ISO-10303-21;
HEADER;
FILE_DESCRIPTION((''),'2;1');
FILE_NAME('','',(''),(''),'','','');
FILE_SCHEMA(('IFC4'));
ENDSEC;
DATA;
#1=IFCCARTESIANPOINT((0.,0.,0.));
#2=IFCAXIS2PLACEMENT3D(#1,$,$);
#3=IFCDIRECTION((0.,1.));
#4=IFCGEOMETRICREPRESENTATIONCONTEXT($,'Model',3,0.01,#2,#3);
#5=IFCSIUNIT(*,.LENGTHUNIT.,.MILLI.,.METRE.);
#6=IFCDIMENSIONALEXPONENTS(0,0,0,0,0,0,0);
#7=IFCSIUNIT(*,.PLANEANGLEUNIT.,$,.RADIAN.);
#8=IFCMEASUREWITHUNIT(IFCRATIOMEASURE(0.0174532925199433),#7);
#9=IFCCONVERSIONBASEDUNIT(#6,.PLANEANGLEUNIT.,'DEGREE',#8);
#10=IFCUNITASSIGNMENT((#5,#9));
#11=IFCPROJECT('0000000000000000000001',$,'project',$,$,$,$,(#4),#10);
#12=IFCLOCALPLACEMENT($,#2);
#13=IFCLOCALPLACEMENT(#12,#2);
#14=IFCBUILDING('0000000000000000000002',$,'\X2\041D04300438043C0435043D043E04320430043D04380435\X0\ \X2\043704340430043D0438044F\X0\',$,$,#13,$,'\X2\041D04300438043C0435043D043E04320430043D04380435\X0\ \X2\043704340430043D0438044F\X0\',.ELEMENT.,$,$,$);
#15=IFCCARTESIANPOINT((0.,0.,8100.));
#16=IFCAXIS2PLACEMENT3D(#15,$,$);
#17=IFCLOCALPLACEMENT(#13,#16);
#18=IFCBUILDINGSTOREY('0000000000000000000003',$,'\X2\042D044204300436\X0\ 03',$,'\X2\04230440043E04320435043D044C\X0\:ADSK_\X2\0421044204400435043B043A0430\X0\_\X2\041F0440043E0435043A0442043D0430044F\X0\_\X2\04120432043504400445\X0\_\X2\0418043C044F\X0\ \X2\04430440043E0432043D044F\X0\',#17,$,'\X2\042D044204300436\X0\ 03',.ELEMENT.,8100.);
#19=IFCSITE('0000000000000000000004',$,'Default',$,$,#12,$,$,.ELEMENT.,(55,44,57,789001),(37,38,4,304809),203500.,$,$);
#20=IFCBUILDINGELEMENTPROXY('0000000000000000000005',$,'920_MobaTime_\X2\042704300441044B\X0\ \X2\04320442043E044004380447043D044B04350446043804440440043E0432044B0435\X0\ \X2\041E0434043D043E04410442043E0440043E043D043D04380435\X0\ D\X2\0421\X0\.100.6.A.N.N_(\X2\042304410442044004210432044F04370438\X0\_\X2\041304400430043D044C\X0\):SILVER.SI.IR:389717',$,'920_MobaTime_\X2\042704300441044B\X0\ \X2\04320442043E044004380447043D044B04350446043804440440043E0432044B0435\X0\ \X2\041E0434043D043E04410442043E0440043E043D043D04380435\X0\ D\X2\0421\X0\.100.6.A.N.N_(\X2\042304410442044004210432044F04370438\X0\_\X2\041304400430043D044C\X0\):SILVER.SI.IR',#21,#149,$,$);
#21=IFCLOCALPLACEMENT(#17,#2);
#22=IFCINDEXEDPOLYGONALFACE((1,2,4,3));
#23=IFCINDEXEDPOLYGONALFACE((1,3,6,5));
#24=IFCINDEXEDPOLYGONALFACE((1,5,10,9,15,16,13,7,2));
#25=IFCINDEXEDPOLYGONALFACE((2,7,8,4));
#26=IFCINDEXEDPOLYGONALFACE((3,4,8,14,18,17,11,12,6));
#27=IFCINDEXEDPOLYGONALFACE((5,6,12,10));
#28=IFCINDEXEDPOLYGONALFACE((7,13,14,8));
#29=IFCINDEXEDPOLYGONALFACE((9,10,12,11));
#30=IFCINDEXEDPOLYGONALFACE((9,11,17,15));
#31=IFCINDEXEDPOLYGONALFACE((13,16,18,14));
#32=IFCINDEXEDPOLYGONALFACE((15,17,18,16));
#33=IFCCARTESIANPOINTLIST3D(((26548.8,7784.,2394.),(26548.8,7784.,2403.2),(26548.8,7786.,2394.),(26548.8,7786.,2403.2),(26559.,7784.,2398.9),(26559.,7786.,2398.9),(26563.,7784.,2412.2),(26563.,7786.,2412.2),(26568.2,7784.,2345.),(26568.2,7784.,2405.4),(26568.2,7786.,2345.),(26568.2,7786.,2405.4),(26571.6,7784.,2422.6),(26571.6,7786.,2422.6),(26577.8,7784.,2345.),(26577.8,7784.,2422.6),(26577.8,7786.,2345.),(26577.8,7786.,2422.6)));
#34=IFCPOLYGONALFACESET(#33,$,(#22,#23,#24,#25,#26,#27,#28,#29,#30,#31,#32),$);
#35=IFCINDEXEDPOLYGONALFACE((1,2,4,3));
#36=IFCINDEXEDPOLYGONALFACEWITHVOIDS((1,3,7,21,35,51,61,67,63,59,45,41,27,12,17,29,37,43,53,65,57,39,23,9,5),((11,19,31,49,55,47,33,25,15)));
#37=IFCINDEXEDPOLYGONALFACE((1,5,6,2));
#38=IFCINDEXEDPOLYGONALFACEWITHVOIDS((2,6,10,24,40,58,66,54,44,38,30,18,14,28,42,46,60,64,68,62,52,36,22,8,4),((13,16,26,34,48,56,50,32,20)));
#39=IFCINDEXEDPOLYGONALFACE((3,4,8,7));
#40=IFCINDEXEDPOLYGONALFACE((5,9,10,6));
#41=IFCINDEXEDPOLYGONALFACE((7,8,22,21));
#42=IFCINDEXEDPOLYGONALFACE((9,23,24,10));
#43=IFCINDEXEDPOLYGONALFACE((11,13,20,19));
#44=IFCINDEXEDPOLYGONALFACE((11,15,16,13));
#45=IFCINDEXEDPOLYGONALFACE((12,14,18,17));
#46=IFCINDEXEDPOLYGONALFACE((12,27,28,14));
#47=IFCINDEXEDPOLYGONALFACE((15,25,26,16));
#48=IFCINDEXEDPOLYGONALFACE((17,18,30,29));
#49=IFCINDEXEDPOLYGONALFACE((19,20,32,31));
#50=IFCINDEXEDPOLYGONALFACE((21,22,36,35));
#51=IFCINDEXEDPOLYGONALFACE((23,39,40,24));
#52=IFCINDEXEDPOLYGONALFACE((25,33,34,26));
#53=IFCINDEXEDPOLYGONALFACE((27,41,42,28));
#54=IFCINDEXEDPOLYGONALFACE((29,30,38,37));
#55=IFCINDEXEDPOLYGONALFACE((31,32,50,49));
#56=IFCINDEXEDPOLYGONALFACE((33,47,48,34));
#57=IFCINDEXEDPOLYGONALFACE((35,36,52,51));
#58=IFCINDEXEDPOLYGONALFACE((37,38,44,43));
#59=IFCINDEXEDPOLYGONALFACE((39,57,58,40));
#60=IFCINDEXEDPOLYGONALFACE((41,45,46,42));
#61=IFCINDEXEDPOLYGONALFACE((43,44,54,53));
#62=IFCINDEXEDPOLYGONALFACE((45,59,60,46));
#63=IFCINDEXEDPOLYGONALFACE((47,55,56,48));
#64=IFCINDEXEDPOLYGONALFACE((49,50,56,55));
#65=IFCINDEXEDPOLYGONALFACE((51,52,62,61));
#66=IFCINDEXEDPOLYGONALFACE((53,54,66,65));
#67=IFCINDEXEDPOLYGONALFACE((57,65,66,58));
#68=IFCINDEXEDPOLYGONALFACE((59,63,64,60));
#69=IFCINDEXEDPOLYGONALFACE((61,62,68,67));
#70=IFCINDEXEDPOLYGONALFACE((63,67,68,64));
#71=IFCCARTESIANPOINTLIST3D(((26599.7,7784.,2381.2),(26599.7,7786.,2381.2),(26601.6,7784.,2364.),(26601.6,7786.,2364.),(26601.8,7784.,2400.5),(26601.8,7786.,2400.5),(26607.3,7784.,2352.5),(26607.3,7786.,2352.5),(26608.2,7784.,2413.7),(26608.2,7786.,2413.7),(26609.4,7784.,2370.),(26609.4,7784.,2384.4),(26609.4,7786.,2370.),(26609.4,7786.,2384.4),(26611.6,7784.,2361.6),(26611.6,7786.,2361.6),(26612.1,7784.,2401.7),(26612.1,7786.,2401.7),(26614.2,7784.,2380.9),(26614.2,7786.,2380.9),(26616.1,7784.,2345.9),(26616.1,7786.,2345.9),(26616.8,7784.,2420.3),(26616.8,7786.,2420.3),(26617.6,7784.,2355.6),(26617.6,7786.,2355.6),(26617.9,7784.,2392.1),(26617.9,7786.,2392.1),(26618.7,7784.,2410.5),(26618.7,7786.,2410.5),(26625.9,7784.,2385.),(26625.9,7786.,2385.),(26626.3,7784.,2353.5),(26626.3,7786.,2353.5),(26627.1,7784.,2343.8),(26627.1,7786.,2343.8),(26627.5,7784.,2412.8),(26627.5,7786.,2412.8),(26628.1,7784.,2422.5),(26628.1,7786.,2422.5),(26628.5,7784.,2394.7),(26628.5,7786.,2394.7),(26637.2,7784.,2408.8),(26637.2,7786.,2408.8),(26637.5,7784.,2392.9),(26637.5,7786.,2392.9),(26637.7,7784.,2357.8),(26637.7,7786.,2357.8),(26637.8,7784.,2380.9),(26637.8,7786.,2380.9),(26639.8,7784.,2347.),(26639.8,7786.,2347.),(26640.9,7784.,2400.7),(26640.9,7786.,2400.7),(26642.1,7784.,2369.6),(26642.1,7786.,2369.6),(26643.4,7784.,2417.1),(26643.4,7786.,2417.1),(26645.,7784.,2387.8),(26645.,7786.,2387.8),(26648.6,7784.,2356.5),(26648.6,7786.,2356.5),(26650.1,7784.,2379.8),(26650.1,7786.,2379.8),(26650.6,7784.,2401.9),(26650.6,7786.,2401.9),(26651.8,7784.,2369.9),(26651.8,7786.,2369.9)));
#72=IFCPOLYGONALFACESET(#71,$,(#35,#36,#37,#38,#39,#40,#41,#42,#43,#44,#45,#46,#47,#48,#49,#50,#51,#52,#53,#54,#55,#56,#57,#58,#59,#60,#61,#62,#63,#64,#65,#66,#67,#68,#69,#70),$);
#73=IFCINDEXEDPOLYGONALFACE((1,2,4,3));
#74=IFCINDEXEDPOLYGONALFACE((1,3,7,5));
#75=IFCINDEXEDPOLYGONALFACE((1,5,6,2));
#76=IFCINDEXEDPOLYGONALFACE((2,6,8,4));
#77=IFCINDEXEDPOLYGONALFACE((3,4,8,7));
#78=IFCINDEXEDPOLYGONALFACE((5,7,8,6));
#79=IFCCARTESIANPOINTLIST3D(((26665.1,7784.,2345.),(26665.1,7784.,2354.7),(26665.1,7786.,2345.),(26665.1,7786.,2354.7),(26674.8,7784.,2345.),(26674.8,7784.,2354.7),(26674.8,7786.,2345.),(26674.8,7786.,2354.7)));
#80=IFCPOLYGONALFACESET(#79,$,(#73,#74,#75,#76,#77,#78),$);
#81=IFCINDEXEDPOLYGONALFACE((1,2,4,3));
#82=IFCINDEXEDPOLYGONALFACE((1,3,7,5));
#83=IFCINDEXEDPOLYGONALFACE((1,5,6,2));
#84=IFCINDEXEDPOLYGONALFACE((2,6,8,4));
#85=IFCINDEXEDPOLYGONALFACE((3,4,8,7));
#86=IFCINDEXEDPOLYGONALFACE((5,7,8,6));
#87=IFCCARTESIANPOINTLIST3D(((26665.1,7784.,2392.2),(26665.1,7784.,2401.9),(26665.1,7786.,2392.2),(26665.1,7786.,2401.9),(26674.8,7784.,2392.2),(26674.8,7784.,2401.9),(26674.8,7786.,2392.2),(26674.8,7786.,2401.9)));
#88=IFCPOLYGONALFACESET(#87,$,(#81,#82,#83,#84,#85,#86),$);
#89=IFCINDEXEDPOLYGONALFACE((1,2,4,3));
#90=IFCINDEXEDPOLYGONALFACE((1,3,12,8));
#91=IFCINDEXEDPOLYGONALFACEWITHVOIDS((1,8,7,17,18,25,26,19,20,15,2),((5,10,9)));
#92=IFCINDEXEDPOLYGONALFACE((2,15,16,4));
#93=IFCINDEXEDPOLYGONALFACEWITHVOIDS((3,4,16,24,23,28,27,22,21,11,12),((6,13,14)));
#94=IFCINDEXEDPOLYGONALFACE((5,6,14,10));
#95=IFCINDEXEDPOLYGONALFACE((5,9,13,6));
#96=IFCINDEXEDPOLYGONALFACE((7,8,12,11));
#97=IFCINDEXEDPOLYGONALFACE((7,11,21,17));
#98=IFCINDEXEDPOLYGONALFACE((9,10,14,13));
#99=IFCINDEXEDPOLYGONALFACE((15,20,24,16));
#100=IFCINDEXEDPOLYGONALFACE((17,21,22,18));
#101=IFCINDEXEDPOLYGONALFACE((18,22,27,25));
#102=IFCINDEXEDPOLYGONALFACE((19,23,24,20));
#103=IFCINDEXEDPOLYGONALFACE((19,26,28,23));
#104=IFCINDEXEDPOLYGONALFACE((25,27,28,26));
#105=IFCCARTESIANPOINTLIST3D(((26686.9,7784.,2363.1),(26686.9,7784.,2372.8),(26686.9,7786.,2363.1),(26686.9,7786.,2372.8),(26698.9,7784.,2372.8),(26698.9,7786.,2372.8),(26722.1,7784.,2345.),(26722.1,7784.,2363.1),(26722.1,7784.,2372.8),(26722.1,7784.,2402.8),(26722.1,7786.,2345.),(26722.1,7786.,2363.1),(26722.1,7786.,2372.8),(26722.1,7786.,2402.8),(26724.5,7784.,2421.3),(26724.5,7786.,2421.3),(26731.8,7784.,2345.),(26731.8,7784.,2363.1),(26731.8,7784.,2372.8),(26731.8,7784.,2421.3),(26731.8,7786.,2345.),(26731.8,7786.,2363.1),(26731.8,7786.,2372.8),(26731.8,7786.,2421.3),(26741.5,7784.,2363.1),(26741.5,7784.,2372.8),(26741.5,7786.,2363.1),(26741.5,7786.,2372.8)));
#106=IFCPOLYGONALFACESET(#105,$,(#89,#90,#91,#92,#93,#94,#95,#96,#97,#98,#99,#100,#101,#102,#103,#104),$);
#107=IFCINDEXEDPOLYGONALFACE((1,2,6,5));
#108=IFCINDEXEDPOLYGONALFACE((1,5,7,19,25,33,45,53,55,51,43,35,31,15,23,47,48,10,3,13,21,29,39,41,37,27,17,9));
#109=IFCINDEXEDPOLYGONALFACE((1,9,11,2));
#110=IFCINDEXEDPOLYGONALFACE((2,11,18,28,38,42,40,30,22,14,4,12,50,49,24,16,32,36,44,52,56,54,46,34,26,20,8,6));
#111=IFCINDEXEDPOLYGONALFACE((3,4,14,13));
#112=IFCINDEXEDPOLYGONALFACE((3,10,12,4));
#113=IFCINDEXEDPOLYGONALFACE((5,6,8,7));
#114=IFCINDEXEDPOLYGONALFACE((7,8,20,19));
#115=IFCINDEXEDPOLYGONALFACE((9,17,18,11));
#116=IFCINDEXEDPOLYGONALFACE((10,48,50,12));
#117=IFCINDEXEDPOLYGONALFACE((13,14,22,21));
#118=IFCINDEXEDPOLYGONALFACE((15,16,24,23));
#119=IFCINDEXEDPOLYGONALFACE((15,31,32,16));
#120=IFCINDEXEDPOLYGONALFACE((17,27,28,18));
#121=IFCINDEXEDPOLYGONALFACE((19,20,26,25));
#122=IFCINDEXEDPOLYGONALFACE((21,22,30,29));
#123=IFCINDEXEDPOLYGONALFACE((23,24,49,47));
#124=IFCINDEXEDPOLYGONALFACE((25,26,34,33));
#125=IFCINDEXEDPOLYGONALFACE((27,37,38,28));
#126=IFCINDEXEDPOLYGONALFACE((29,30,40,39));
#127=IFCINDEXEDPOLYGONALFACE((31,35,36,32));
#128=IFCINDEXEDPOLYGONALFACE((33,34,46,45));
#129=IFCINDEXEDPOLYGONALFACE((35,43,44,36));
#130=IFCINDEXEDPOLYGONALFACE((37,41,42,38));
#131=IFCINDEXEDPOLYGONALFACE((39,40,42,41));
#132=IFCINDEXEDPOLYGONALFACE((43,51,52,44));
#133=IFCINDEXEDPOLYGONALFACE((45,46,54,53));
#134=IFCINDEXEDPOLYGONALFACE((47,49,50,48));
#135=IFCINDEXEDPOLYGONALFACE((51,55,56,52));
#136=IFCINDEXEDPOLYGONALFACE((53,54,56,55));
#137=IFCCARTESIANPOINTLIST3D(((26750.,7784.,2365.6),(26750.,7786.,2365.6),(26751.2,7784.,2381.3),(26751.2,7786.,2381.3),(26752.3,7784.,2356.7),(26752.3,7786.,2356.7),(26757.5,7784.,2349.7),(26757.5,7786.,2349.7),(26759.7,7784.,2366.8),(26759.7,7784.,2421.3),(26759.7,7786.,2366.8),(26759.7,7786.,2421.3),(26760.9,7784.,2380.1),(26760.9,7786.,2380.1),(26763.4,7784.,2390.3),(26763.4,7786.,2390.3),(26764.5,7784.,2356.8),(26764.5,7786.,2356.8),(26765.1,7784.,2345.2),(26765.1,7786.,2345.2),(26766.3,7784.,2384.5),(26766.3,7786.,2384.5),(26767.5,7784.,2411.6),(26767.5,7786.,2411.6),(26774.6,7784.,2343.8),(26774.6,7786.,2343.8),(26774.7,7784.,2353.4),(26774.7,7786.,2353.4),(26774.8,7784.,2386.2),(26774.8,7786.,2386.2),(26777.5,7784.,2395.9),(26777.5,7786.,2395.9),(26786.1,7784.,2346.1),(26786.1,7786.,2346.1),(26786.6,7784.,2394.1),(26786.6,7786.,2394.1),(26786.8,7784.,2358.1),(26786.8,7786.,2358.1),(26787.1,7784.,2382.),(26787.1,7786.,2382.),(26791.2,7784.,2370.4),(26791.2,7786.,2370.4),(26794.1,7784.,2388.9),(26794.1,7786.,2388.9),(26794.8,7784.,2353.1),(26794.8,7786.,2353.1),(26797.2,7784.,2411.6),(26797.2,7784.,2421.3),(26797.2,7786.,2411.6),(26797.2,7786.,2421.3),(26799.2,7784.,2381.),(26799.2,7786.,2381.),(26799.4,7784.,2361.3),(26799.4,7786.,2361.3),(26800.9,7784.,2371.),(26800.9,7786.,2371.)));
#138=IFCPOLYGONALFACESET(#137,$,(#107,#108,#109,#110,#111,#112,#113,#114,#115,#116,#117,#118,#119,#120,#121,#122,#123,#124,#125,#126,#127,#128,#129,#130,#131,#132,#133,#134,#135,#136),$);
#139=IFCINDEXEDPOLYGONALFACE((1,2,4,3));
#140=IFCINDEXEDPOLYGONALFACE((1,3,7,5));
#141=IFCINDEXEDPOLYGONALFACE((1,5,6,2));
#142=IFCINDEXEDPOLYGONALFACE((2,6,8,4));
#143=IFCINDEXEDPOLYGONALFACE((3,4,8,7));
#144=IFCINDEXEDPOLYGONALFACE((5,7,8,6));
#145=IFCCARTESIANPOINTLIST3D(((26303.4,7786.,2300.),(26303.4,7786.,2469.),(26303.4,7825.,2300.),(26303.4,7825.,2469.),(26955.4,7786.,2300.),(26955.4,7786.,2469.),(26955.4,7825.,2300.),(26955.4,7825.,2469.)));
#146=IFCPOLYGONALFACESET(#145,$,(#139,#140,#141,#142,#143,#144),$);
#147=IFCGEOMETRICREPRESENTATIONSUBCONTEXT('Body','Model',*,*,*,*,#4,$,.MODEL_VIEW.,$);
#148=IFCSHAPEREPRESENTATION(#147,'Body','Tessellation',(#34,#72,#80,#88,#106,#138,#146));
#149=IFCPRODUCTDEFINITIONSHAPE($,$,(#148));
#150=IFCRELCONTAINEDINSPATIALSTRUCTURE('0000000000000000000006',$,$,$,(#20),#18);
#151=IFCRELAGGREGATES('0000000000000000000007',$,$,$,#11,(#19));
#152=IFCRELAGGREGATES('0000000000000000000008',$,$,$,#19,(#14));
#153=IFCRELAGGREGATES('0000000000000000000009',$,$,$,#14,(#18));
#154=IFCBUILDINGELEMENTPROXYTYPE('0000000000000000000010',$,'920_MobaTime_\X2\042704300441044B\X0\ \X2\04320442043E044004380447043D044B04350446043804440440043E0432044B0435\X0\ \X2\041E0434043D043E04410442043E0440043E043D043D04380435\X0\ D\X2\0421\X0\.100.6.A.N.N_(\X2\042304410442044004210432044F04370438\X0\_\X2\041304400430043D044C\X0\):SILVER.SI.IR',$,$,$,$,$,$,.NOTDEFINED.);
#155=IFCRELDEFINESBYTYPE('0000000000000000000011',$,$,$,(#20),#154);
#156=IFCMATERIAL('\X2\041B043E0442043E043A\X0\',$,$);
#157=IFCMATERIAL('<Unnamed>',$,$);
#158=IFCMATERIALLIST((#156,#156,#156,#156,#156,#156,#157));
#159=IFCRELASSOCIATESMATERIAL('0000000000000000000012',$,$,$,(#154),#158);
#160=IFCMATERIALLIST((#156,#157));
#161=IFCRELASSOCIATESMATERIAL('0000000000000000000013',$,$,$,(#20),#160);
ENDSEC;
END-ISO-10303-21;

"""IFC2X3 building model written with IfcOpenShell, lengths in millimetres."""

from ifc_helpers import new_model, entity, si_unit, converted_unit, direction, frame, origin, origin_2d_with_axis, place, context, subcontext, project, spatial, polyline, rectangle, outline, extrude, source, transform, mapped, material, material_list, type_object, type_shapes, element, save


model = new_model("IFC2X3")

# Units and contexts
model_context = context("Model", 3, precision=0.01, world=origin(), true_north=direction((0.0, 1.0)))
body_context = subcontext(model_context, "Body", "Model", "MODEL_VIEW")
ifc_project = project(units=[si_unit("LENGTHUNIT", "METRE", prefix="MILLI"), converted_unit("PLANEANGLEUNIT", "DEGREE", entity("IfcRatioMeasure", 0.0174532925199433), si_unit("PLANEANGLEUNIT", "RADIAN"), dimensions=[0, 0, 0, 0, 0, 0, 0])], contexts=[model_context])

# Site, building, storey
site_placement = place(None, origin())
site = spatial("IfcSite", under=ifc_project, at=site_placement, Name="Default", CompositionType="ELEMENT", RefLatitude=(55, 44, 57, 789001), RefLongitude=(37, 38, 4, 304809), RefElevation=203500.0)
building_placement = place(site_placement, origin())
building = spatial("IfcBuilding", under=site, at=building_placement, Name="Наименование здания", LongName="Наименование здания", CompositionType="ELEMENT")
storey_placement = place(building_placement, frame((0.0, 0.0, 8100.0)))
storey = spatial("IfcBuildingStorey", under=building, at=storey_placement, Name="Этаж 03", ObjectType="Уровень:ADSK_Стрелка_Проектная_Вверх_Имя уровня", LongName="Этаж 03", CompositionType="ELEMENT", Elevation=8100.0)

# Building element proxy
ifc_material_1 = material(Name="Лоток")
ifc_material_2 = material(Name="<Unnamed>")
ifc_material_list_1 = material_list([ifc_material_1, ifc_material_1, ifc_material_1, ifc_material_1, ifc_material_1, ifc_material_1, ifc_material_2])
building_element_proxy_type = type_object("IfcBuildingElementProxyType", Name="920_MobaTime_Часы вторичныецифровые Односторонние DС.100.6.A.N.N_(УстрСвязи_Грань):SILVER.SI.IR", PredefinedType="NOTDEFINED", material=ifc_material_list_1)
shared_shape = source(origin(), body_context, "Body", "SweptSolid", [
    extrude(outline(polyline([(-49.3, -13.1), (28.2, -13.1), (28.2, -6.8), (17.9, 1.8), (8.8, 16.0), (-0.3, 16.0), (4.6, 5.8), (11.1, -3.4), (-49.3, -3.4), (-49.3, -13.1)])), frame((-64.6, 9.8, 39.0), z_axis=(0.0, 0.0, 1.0), x_axis=(0.0, 1.0, 0.0)), (0.0, 0.0, 1.0), 2.0),
    extrude(outline(polyline([(2.2, -27.6), (19.0, -27.6), (30.5, -16.1), (33.3, -4.9), (31.0, 5.8), (21.8, 17.2), (5.2, 27.3), (-11.1, 33.0), (-24.0, 32.7), (-33.6, 27.6), (-40.3, 18.6), (-42.8, 5.7), (-38.0, -6.3), (-27.2, -14.9), (-17.5, -17.7), (-8.2, -16.4), (-0.3, -11.9), (5.1, -4.5), (7.3, 6.2), (4.0, 17.2), (18.4, 7.3), (23.6, -2.4), (22.0, -11.4), (14.2, -18.4), (5.3, -18.3), (2.2, -27.6)]), holes=[polyline([(-9.0, 23.3), (-1.3, 14.3), (-2.5, 2.0), (-11.4, -7.0), (-23.4, -6.0), (-32.2, 2.9), (-31.2, 15.1), (-25.6, 22.1), (-17.5, 24.9), (-9.0, 23.3)])]), frame((-2.7, 3.6, 39.0), z_axis=(0.0, 0.0, 1.0), x_axis=(-0.427649, 0.903945, 0.0)), (0.0, 0.0, 1.0), 2.0),
    extrude(rectangle(XDim=9.7, YDim=9.7, at=origin_2d_with_axis()), frame((40.6, -34.7, 39.0)), (0.0, 0.0, 1.0), 2.0),
    extrude(rectangle(XDim=9.7, YDim=9.7, at=origin_2d_with_axis()), frame((40.6, 12.6, 39.0)), (0.0, 0.0, 1.0), 2.0),
    extrude(outline(polyline([(-0.9, -28.1), (8.8, -28.1), (8.8, -9.9), (18.5, -9.9), (18.5, -0.2), (8.8, -0.2), (8.8, 48.3), (1.5, 48.3), (-36.0, -0.2), (-36.0, -9.9), (-0.9, -9.9), (-0.9, -28.1)]), holes=[polyline([(-0.9, -0.2), (-24.1, -0.2), (-0.9, 29.7), (-0.9, -0.2)])]), frame((93.6, -11.4, 39.0)), (0.0, 0.0, 1.0), 2.0),
    extrude(outline(polyline([(3.3, -28.3), (12.5, -28.3), (20.5, -25.0), (26.8, -18.9), (30.7, -10.0), (31.4, 1.6), (26.9, 11.8), (20.1, 18.4), (11.1, 22.3), (1.0, 23.3), (-7.9, 20.4), (-14.9, 14.5), (-18.9, 6.2), (-17.1, -9.0), (-36.7, 0.5), (-29.1, 29.2), (-38.5, 31.7), (-48.1, -4.6), (-11.6, -23.1), (-8.0, -14.0), (-10.8, -7.6), (-10.2, 1.1), (-3.0, 11.8), (9.2, 12.8), (20.0, 5.5), (21.4, -7.5), (15.5, -16.4), (4.6, -18.6), (3.3, -28.3)])), frame((147.1, -8.5, 39.0), z_axis=(0.0, 0.0, 1.0), x_axis=(0.256974, -0.966418, 0.0)), (0.0, 0.0, 1.0), 2.0),
    extrude(rectangle(XDim=652.0, YDim=169.0, at=origin_2d_with_axis()), frame((0.0, 0.0, 0.0), z_axis=(0.0, 0.0, 1.0), x_axis=(-1.0, 0.0, 0.0)), (0.0, 0.0, 1.0), 39.0),
])
type_shapes(building_element_proxy_type, [shared_shape])
ifc_material_list_2 = material_list([ifc_material_1, ifc_material_2])
for number, where, z_axis, x_axis, name in (
    (1, (26629.4, 7825.0, 2384.5), (0.0, -1.0, 0.0), (1.0, 0.0, 0.0), "920_MobaTime_Часы вторичныецифровые Односторонние DС.100.6.A.N.N_(УстрСвязи_Грань):SILVER.SI.IR:389717"),
):
    element("IfcBuildingElementProxy", number, at=place(storey_placement, frame(where, z_axis=z_axis, x_axis=x_axis)), inside=storey, type_object=building_element_proxy_type, material=ifc_material_list_2, Name=name, ObjectType="920_MobaTime_Часы вторичныецифровые Односторонние DС.100.6.A.N.N_(УстрСвязи_Грань):SILVER.SI.IR", context=body_context, shape_type="MappedRepresentation", body=[
        mapped(shared_shape, transform((0.0, 0.0, 0.0), scale=1.0)),
    ])

save(model, "model.ifc")
